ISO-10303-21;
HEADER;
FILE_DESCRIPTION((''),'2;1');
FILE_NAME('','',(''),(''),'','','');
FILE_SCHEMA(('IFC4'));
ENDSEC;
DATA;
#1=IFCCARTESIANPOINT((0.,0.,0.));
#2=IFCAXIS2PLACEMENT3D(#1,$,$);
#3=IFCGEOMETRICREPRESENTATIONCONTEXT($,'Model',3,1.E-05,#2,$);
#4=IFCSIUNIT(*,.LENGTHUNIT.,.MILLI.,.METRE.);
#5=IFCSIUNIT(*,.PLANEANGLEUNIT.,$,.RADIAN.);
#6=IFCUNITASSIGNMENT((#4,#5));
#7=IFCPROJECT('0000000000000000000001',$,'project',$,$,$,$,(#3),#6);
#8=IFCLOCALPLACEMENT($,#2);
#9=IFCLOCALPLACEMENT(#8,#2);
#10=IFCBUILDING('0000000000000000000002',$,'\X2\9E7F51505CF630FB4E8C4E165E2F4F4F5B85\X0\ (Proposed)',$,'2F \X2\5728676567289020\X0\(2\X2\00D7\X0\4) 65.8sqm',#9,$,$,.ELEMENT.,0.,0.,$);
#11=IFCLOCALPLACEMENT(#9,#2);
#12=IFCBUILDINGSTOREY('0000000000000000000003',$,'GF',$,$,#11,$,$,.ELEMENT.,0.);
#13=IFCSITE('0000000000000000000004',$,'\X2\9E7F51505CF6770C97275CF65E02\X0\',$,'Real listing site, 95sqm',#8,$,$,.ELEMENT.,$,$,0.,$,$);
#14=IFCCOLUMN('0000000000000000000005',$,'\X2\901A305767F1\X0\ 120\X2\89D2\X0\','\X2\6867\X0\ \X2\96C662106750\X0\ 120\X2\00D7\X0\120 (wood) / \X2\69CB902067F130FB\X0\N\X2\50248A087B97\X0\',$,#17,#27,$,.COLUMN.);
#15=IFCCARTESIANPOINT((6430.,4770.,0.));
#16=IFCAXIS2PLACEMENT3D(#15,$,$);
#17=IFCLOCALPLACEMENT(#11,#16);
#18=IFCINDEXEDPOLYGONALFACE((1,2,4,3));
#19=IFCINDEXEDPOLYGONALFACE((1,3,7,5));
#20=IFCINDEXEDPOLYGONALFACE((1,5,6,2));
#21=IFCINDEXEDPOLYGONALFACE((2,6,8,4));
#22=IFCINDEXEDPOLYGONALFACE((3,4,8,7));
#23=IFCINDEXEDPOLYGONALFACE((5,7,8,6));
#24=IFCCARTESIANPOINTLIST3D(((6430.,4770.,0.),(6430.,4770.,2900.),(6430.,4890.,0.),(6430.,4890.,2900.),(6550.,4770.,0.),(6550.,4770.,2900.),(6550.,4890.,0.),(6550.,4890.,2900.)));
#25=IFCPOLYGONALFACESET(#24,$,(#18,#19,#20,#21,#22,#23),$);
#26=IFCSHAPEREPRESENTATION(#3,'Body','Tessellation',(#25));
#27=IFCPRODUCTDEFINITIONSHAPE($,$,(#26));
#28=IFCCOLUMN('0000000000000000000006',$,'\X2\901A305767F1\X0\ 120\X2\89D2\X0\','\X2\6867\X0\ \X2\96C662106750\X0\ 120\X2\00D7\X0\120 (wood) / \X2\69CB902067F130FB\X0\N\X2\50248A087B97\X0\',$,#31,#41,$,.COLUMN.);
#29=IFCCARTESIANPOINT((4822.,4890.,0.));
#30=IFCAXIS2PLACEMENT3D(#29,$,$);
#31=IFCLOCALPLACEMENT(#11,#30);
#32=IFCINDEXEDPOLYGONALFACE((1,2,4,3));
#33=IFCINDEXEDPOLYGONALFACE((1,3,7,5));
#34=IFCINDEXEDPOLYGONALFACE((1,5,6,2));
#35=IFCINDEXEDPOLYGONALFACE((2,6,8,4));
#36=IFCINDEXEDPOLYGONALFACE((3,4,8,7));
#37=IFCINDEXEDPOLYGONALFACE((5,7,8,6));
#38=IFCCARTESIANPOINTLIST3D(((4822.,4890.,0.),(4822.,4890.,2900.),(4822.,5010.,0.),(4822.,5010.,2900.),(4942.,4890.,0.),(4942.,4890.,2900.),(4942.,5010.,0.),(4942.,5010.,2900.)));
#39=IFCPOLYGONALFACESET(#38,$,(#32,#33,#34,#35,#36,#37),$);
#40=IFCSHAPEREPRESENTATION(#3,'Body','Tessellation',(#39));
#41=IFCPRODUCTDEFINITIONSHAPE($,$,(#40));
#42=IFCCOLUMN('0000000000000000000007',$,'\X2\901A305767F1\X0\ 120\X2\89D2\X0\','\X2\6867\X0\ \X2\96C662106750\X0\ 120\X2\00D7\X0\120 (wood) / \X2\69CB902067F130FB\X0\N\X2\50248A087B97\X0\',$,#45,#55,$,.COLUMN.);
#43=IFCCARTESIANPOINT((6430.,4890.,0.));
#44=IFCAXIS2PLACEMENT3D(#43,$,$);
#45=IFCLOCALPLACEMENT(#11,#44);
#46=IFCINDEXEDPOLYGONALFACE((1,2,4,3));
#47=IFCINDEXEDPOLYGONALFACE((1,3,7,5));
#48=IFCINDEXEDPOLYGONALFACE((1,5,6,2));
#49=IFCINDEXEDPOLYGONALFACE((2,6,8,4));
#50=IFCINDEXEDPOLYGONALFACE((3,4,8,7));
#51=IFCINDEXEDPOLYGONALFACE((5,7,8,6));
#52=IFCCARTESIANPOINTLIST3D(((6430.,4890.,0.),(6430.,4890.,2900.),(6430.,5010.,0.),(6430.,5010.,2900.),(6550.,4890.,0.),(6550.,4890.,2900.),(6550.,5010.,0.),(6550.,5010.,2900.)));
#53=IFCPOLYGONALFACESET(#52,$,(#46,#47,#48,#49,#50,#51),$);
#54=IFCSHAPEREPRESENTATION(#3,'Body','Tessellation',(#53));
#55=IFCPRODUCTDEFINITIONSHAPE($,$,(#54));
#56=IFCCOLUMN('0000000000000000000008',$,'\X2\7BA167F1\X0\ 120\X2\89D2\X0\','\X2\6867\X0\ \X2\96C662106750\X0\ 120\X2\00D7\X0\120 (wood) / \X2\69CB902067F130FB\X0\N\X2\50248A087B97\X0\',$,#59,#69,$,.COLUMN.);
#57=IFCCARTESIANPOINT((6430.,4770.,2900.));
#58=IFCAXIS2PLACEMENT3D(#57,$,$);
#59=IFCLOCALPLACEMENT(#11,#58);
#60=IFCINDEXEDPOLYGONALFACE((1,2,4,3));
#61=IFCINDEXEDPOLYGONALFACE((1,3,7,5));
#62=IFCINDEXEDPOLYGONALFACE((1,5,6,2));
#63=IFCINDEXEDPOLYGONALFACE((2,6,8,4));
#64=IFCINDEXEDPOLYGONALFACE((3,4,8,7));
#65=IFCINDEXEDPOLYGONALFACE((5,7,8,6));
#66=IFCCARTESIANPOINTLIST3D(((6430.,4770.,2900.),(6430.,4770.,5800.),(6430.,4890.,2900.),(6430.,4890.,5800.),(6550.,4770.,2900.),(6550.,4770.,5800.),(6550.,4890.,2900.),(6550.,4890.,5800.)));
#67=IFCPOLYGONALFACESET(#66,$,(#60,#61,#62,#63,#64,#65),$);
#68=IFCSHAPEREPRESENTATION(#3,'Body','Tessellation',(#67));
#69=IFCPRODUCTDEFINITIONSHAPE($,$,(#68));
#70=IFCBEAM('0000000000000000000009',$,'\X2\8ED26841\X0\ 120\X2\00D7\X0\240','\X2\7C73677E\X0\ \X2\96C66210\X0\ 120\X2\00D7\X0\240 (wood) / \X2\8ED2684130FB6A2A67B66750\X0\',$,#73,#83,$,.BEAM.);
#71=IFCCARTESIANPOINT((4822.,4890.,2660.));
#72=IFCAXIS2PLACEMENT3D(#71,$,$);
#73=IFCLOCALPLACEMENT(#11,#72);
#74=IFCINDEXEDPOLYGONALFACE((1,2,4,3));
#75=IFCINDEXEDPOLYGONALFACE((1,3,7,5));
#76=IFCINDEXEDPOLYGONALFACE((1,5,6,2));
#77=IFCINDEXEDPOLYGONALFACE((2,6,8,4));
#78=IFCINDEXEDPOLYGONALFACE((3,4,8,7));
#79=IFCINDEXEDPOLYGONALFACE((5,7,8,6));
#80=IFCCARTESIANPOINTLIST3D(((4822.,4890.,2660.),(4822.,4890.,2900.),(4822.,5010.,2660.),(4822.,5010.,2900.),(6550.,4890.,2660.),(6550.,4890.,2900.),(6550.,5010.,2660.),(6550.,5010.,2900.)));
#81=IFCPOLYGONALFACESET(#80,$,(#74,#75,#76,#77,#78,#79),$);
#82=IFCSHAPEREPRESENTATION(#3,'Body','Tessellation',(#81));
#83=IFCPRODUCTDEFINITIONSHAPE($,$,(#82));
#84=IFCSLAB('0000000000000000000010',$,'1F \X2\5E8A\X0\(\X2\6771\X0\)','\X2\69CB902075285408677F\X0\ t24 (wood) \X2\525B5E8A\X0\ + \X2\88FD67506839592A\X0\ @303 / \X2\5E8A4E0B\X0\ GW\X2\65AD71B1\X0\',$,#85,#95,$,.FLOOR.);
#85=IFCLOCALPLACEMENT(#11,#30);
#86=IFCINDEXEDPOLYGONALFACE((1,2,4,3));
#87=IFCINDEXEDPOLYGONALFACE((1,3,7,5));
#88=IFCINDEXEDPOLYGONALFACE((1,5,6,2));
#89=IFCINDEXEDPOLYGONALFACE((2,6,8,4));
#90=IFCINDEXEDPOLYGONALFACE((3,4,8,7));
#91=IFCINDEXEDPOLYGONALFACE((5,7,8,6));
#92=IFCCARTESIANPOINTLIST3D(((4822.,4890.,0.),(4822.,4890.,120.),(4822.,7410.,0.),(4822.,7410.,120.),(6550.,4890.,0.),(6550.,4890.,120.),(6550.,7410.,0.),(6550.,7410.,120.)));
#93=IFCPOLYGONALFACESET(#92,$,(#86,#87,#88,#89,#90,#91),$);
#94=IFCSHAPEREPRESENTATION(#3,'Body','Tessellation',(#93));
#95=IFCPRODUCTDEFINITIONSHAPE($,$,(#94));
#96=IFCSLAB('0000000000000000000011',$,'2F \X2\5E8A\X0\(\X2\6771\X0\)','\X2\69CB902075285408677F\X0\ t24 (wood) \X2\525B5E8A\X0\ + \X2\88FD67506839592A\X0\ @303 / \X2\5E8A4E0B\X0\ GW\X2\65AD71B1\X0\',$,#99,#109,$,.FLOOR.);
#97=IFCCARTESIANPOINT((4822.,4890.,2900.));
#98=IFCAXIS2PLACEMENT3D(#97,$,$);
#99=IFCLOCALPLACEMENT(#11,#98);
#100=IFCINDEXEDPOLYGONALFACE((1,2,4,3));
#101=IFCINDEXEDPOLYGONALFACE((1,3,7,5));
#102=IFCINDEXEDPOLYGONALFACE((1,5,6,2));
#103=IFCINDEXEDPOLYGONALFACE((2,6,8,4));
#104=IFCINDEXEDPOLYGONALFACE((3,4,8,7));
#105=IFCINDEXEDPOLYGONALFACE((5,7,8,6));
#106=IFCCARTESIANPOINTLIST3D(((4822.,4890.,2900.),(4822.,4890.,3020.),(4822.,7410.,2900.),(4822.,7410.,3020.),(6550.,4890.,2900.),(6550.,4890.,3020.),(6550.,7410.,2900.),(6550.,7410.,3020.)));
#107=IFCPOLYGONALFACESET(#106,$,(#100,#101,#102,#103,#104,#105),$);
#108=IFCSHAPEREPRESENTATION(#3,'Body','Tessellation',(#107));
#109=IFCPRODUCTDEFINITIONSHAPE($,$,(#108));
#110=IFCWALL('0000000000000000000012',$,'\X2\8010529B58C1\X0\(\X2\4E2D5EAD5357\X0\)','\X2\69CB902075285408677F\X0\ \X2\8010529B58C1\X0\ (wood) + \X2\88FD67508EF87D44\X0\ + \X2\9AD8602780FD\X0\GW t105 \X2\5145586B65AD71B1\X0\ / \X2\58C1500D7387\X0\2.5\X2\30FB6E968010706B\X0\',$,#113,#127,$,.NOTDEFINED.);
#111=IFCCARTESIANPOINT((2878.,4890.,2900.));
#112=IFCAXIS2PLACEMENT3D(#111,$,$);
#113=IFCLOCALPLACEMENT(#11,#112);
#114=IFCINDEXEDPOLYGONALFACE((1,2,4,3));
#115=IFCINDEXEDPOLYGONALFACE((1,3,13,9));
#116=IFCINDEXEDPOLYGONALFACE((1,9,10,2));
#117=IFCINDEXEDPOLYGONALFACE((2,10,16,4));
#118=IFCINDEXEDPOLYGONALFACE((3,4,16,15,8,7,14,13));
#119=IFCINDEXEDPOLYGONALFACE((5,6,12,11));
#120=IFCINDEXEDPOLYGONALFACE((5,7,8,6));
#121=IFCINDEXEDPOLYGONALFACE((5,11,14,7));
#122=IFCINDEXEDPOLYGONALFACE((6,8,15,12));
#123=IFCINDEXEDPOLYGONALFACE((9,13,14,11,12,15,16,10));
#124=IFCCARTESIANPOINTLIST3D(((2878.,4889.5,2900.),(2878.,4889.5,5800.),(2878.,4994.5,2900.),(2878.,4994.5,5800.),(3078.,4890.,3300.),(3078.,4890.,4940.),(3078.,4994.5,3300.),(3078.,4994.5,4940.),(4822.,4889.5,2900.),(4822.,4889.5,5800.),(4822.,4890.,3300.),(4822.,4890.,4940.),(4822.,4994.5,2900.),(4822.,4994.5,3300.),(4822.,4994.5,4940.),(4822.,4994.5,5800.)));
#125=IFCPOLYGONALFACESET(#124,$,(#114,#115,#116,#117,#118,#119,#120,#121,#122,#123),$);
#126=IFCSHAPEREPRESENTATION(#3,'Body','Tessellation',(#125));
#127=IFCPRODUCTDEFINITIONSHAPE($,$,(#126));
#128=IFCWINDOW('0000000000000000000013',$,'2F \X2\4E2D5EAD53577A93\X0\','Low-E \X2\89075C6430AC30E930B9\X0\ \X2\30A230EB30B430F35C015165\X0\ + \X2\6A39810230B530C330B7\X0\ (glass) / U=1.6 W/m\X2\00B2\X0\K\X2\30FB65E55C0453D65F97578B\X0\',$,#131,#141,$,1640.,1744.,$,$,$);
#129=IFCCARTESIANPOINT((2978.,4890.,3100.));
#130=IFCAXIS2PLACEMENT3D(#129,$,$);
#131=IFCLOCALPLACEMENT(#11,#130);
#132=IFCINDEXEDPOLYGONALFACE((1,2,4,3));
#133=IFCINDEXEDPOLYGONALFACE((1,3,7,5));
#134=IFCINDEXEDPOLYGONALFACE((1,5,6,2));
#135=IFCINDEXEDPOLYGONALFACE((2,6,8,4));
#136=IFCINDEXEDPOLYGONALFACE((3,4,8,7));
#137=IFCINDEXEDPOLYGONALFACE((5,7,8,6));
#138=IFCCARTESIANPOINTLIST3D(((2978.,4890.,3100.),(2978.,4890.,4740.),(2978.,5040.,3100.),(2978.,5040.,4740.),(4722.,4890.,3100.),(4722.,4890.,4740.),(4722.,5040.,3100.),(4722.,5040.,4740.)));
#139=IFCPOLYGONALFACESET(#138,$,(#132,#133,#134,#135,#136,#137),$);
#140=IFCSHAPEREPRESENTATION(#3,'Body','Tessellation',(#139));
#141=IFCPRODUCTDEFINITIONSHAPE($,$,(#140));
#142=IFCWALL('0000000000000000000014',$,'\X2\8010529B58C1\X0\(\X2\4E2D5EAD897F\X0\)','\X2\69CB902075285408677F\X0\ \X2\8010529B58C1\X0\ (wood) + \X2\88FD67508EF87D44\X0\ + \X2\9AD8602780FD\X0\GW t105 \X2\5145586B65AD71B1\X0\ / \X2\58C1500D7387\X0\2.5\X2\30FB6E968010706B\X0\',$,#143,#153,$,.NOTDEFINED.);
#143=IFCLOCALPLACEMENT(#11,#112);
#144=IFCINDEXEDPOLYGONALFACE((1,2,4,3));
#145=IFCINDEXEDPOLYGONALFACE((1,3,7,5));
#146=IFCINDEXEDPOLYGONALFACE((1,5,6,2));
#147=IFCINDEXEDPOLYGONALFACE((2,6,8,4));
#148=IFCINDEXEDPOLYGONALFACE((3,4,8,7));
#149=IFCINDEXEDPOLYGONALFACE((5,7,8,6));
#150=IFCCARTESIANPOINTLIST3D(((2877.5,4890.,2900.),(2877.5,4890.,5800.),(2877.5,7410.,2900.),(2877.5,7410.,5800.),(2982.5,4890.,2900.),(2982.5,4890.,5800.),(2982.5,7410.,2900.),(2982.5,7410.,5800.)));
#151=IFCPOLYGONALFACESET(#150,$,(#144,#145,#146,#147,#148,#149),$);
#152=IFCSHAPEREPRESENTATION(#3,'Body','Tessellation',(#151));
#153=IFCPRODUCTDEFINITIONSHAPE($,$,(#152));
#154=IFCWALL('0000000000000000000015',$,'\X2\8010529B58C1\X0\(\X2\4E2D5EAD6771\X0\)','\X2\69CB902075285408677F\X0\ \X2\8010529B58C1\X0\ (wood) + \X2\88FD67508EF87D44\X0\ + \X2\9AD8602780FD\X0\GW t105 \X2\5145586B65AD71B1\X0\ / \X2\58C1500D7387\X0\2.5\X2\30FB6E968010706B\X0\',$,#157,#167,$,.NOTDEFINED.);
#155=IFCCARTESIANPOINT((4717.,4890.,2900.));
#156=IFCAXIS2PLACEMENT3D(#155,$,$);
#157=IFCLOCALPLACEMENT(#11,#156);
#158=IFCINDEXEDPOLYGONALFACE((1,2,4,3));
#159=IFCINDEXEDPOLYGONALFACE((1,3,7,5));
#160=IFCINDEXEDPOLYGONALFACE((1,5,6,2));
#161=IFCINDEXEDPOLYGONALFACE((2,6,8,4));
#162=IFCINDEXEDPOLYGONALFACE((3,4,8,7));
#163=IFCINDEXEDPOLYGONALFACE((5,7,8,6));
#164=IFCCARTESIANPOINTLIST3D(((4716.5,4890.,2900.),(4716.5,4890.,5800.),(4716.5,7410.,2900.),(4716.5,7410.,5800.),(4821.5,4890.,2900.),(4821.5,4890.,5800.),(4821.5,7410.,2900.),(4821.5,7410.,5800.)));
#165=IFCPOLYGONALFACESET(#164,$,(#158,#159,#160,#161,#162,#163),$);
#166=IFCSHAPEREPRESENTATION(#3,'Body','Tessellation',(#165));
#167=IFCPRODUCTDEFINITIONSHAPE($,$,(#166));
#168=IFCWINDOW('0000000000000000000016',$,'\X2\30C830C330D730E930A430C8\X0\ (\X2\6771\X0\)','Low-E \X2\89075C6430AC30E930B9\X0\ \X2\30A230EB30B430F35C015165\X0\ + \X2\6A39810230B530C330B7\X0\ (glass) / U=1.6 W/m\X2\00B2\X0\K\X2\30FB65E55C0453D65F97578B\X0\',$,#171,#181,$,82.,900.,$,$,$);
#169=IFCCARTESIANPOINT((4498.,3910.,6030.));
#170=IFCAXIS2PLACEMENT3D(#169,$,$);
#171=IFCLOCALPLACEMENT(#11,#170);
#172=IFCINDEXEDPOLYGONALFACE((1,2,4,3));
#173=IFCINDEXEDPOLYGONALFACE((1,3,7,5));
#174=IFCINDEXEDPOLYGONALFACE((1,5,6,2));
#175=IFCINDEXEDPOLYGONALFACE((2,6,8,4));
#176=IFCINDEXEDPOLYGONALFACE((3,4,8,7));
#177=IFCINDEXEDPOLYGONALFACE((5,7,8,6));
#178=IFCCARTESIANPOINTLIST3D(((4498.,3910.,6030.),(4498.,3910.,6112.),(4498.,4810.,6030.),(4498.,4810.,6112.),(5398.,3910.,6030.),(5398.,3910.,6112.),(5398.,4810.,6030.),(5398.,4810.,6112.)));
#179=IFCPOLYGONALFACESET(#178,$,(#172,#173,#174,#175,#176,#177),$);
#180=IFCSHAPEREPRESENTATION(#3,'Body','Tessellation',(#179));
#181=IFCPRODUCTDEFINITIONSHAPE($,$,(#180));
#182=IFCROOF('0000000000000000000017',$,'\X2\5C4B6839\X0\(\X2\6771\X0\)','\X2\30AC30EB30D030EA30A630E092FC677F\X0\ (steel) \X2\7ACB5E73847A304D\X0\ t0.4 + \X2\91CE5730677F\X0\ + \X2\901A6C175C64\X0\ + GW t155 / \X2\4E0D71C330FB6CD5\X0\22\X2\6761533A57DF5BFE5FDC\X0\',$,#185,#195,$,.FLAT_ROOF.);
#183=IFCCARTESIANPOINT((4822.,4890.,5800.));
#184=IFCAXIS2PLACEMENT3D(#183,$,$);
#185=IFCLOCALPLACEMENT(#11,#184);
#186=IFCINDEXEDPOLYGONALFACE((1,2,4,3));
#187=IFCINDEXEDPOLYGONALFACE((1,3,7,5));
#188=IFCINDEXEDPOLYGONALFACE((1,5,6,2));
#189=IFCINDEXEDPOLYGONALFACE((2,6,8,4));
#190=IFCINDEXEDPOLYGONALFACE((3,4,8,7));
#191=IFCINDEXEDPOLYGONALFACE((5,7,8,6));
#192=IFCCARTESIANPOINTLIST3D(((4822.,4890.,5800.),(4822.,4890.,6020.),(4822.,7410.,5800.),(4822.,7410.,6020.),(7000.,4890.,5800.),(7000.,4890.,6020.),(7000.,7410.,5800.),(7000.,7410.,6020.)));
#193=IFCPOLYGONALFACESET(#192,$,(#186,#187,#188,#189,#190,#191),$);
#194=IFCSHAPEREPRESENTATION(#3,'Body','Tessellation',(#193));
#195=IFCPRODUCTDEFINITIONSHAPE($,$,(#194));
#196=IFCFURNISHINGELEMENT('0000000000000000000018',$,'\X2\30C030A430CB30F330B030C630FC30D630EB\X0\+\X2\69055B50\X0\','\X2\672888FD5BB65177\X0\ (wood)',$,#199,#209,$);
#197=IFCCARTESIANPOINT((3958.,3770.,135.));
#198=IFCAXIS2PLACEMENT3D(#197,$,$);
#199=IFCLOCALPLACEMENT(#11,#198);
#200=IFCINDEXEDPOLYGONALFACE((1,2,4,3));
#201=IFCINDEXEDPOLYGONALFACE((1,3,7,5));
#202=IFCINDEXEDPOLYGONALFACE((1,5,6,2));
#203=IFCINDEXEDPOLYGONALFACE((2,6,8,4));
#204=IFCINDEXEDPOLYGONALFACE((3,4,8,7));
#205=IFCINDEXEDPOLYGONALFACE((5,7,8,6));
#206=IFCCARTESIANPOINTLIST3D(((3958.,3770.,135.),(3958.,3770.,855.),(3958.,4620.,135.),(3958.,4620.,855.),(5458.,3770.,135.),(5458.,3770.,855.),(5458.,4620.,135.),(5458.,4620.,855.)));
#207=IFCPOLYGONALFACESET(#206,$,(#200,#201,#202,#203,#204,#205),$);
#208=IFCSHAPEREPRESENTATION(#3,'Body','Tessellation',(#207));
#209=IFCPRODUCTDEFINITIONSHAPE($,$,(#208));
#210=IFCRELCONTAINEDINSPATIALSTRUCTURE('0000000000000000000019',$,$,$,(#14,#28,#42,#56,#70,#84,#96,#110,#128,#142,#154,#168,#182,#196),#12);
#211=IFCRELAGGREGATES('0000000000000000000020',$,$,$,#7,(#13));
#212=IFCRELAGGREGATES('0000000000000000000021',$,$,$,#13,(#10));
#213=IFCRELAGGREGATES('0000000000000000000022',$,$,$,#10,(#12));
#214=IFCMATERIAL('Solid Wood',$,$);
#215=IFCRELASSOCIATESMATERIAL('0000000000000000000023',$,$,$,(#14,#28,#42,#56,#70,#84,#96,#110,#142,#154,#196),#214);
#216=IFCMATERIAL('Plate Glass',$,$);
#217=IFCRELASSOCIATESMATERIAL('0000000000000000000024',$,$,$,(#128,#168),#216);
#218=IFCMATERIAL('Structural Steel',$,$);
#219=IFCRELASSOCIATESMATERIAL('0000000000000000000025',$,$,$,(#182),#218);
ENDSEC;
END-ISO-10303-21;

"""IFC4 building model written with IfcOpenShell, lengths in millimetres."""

from ifc_helpers import new_model, si_unit, frame, frame_2d, origin, place, context, project, spatial, rectangle, extrude, material, element, fill, save


model = new_model("IFC4")

# Units and contexts
model_context = context("Model", 3, precision=1e-05, world=origin())
ifc_project = project(units=[si_unit("LENGTHUNIT", "METRE", prefix="MILLI"), si_unit("PLANEANGLEUNIT", "RADIAN")], contexts=[model_context])

# Site, building, storey
site_placement = place(None, origin())
site = spatial("IfcSite", under=ifc_project, at=site_placement, Name="鹿児島県霧島市", ObjectType="Real listing site, 95sqm", CompositionType="ELEMENT", RefElevation=0.0)
building_placement = place(site_placement, origin())
building = spatial("IfcBuilding", under=site, at=building_placement, Name="鹿児島・二世帯住宅 (Proposed)", ObjectType="2F 在来木造(2×4) 65.8sqm", CompositionType="ELEMENT", ElevationOfRefHeight=0.0, ElevationOfTerrain=0.0)
storey_placement = place(building_placement, origin())
storey = spatial("IfcBuildingStorey", under=building, at=storey_placement, Name="GF", CompositionType="ELEMENT", Elevation=0.0)

# Columns
ifc_material_1 = material(Name="Solid Wood")
column_1_placement = place(storey_placement, frame((6430.0, 4770.0, 0.0)))
element("IfcColumn", 1, at=column_1_placement, inside=storey, material=ifc_material_1, Name="通し柱 120角", Description="桧 集成材 120×120 (wood) / 構造柱・N値計算", PredefinedType="COLUMN", context=model_context, shape_type="SweptSolid", body=[
    extrude(rectangle(XDim=120.0, YDim=120.0, at=frame_2d((60.0, 60.0))), frame((6430.0, 4770.0, 0.0)), (0.0, 0.0, 1.0), 2900.0),
])
column_2_placement = place(storey_placement, frame((4822.0, 4890.0, 0.0)))
element("IfcColumn", 2, at=column_2_placement, inside=storey, material=ifc_material_1, Name="通し柱 120角", Description="桧 集成材 120×120 (wood) / 構造柱・N値計算", PredefinedType="COLUMN", context=model_context, shape_type="SweptSolid", body=[
    extrude(rectangle(XDim=120.0, YDim=120.0, at=frame_2d((60.0, 60.0))), frame((4822.0, 4890.0, 0.0)), (0.0, 0.0, 1.0), 2900.0),
])
column_3_placement = place(storey_placement, frame((6430.0, 4890.0, 0.0)))
element("IfcColumn", 3, at=column_3_placement, inside=storey, material=ifc_material_1, Name="通し柱 120角", Description="桧 集成材 120×120 (wood) / 構造柱・N値計算", PredefinedType="COLUMN", context=model_context, shape_type="SweptSolid", body=[
    extrude(rectangle(XDim=120.0, YDim=120.0, at=frame_2d((60.0, 60.0))), frame((6430.0, 4890.0, 0.0)), (0.0, 0.0, 1.0), 2900.0),
])
column_4_placement = place(storey_placement, frame((6430.0, 4770.0, 2900.0)))
element("IfcColumn", 4, at=column_4_placement, inside=storey, material=ifc_material_1, Name="管柱 120角", Description="桧 集成材 120×120 (wood) / 構造柱・N値計算", PredefinedType="COLUMN", context=model_context, shape_type="SweptSolid", body=[
    extrude(rectangle(XDim=120.0, YDim=120.0, at=frame_2d((60.0, 60.0))), frame((6430.0, 4770.0, 2900.0)), (0.0, 0.0, 1.0), 2900.0),
])

# Beam
beam_1_placement = place(storey_placement, frame((4822.0, 4890.0, 2660.0)))
element("IfcBeam", 5, at=beam_1_placement, inside=storey, material=ifc_material_1, Name="軒桁 120×240", Description="米松 集成 120×240 (wood) / 軒桁・横架材", PredefinedType="BEAM", context=model_context, shape_type="SweptSolid", body=[
    extrude(rectangle(XDim=1728.0, YDim=120.0, at=frame_2d((864.0, 60.0))), frame((4822.0, 4890.0, 2660.0)), (0.0, 0.0, 1.0), 240.0),
])

# Slabs
slab_1_placement = place(storey_placement, frame((4822.0, 4890.0, 0.0)))
element("IfcSlab", 6, at=slab_1_placement, inside=storey, material=ifc_material_1, Name="1F 床(東)", Description="構造用合板 t24 (wood) 剛床 + 製材根太 @303 / 床下 GW断熱", PredefinedType="FLOOR", context=model_context, shape_type="SweptSolid", body=[
    extrude(rectangle(XDim=1728.0, YDim=2520.0, at=frame_2d((864.0, 1260.0))), frame((4822.0, 4890.0, 0.0)), (0.0, 0.0, 1.0), 120.0),
])
slab_2_placement = place(storey_placement, frame((4822.0, 4890.0, 2900.0)))
element("IfcSlab", 7, at=slab_2_placement, inside=storey, material=ifc_material_1, Name="2F 床(東)", Description="構造用合板 t24 (wood) 剛床 + 製材根太 @303 / 床下 GW断熱", PredefinedType="FLOOR", context=model_context, shape_type="SweptSolid", body=[
    extrude(rectangle(XDim=1728.0, YDim=2520.0, at=frame_2d((864.0, 1260.0))), frame((4822.0, 4890.0, 2900.0)), (0.0, 0.0, 1.0), 120.0),
])

# Wall, opening, window
wall_1_placement = place(storey_placement, frame((2878.0, 4890.0, 2900.0)))
wall_1 = element("IfcWall", 8, at=wall_1_placement, inside=storey, material=ifc_material_1, Name="耐力壁(中庭南)", Description="構造用合板 耐力壁 (wood) + 製材軸組 + 高性能GW t105 充填断熱 / 壁倍率2.5・準耐火", PredefinedType="NOTDEFINED", context=model_context, shape_type="SweptSolid", body=[
    extrude(rectangle(XDim=1944.0, YDim=105.0, at=frame_2d((972.0, 52.0))), frame((2878.0, 4890.0, 2900.0)), (0.0, 0.0, 1.0), 2900.0),
])
opening_placement = place(storey_placement, frame((2978.0, 4890.0, 3100.0)))
opening = element("IfcOpeningElement", 9, at=opening_placement, cuts=wall_1, PredefinedType="NOTDEFINED", context=model_context, shape_type="SweptSolid", body=[
    extrude(rectangle(XDim=1744.0, YDim=150.0, at=frame_2d((872.0, 75.0))), frame((2978.0, 4890.0, 3100.0)), (0.0, 0.0, 1.0), 1640.0),
])
ifc_material_2 = material(Name="Plate Glass")
window_1_placement = place(storey_placement, frame((2978.0, 4890.0, 3100.0)))
window_1 = element("IfcWindow", 10, at=window_1_placement, inside=storey, material=ifc_material_2, Name="2F 中庭南窓", Description="Low-E 複層ガラス アルゴン封入 + 樹脂サッシ (glass) / U=1.6 W/m²K・日射取得型", OverallHeight=1640.0, OverallWidth=1744.0, context=model_context, shape_type="SweptSolid", body=[
    extrude(rectangle(XDim=1744.0, YDim=150.0, at=frame_2d((872.0, 75.0))), frame((2978.0, 4890.0, 3100.0)), (0.0, 0.0, 1.0), 1640.0),
])
fill(opening, window_1)

# Walls
wall_2_placement = place(storey_placement, frame((2878.0, 4890.0, 2900.0)))
element("IfcWall", 11, at=wall_2_placement, inside=storey, material=ifc_material_1, Name="耐力壁(中庭西)", Description="構造用合板 耐力壁 (wood) + 製材軸組 + 高性能GW t105 充填断熱 / 壁倍率2.5・準耐火", PredefinedType="NOTDEFINED", context=model_context, shape_type="SweptSolid", body=[
    extrude(rectangle(XDim=105.0, YDim=2520.0, at=frame_2d((52.0, 1260.0))), frame((2878.0, 4890.0, 2900.0)), (0.0, 0.0, 1.0), 2900.0),
])
wall_3_placement = place(storey_placement, frame((4717.0, 4890.0, 2900.0)))
element("IfcWall", 12, at=wall_3_placement, inside=storey, material=ifc_material_1, Name="耐力壁(中庭東)", Description="構造用合板 耐力壁 (wood) + 製材軸組 + 高性能GW t105 充填断熱 / 壁倍率2.5・準耐火", PredefinedType="NOTDEFINED", context=model_context, shape_type="SweptSolid", body=[
    extrude(rectangle(XDim=105.0, YDim=2520.0, at=frame_2d((52.0, 1260.0))), frame((4717.0, 4890.0, 2900.0)), (0.0, 0.0, 1.0), 2900.0),
])

# Window
window_2_placement = place(storey_placement, frame((4498.0, 3910.0, 6030.0)))
element("IfcWindow", 13, at=window_2_placement, inside=storey, material=ifc_material_2, Name="トップライト (東)", Description="Low-E 複層ガラス アルゴン封入 + 樹脂サッシ (glass) / U=1.6 W/m²K・日射取得型", OverallHeight=82.0, OverallWidth=900.0, context=model_context, shape_type="SweptSolid", body=[
    extrude(rectangle(XDim=900.0, YDim=900.0, at=frame_2d((450.0, 450.0))), frame((4498.0, 3910.0, 6030.0)), (0.0, 0.0, 1.0), 82.0),
])

# Roof
ifc_material_3 = material(Name="Structural Steel")
for number, where, name in (
    (14, (4822.0, 4890.0, 5800.0), "屋根(東)"),
):
    element("IfcRoof", number, at=place(storey_placement, frame(where)), inside=storey, material=ifc_material_3, Name=name, Description="ガルバリウム鋼板 (steel) 立平葺き t0.4 + 野地板 + 通気層 + GW t155 / 不燃・法22条区域対応", PredefinedType="FLAT_ROOF", context=model_context, shape_type="SweptSolid", body=[
        extrude(rectangle(XDim=2178.0, YDim=2520.0, at=frame_2d((1089.0, 1260.0))), frame((4822.0, 4890.0, 5800.0)), (0.0, 0.0, 1.0), 220.0),
    ])

# Furnishing element
furnishing_1_placement = place(storey_placement, frame((3958.0, 3770.0, 135.0)))
element("IfcFurnishingElement", 15, at=furnishing_1_placement, inside=storey, material=ifc_material_1, Name="ダイニングテーブル+椅子", Description="木製家具 (wood)", context=model_context, shape_type="SweptSolid", body=[
    extrude(rectangle(XDim=1500.0, YDim=850.0, at=frame_2d((750.0, 425.0))), frame((3958.0, 3770.0, 135.0)), (0.0, 0.0, 1.0), 720.0),
])

save(model, "model.ifc")
